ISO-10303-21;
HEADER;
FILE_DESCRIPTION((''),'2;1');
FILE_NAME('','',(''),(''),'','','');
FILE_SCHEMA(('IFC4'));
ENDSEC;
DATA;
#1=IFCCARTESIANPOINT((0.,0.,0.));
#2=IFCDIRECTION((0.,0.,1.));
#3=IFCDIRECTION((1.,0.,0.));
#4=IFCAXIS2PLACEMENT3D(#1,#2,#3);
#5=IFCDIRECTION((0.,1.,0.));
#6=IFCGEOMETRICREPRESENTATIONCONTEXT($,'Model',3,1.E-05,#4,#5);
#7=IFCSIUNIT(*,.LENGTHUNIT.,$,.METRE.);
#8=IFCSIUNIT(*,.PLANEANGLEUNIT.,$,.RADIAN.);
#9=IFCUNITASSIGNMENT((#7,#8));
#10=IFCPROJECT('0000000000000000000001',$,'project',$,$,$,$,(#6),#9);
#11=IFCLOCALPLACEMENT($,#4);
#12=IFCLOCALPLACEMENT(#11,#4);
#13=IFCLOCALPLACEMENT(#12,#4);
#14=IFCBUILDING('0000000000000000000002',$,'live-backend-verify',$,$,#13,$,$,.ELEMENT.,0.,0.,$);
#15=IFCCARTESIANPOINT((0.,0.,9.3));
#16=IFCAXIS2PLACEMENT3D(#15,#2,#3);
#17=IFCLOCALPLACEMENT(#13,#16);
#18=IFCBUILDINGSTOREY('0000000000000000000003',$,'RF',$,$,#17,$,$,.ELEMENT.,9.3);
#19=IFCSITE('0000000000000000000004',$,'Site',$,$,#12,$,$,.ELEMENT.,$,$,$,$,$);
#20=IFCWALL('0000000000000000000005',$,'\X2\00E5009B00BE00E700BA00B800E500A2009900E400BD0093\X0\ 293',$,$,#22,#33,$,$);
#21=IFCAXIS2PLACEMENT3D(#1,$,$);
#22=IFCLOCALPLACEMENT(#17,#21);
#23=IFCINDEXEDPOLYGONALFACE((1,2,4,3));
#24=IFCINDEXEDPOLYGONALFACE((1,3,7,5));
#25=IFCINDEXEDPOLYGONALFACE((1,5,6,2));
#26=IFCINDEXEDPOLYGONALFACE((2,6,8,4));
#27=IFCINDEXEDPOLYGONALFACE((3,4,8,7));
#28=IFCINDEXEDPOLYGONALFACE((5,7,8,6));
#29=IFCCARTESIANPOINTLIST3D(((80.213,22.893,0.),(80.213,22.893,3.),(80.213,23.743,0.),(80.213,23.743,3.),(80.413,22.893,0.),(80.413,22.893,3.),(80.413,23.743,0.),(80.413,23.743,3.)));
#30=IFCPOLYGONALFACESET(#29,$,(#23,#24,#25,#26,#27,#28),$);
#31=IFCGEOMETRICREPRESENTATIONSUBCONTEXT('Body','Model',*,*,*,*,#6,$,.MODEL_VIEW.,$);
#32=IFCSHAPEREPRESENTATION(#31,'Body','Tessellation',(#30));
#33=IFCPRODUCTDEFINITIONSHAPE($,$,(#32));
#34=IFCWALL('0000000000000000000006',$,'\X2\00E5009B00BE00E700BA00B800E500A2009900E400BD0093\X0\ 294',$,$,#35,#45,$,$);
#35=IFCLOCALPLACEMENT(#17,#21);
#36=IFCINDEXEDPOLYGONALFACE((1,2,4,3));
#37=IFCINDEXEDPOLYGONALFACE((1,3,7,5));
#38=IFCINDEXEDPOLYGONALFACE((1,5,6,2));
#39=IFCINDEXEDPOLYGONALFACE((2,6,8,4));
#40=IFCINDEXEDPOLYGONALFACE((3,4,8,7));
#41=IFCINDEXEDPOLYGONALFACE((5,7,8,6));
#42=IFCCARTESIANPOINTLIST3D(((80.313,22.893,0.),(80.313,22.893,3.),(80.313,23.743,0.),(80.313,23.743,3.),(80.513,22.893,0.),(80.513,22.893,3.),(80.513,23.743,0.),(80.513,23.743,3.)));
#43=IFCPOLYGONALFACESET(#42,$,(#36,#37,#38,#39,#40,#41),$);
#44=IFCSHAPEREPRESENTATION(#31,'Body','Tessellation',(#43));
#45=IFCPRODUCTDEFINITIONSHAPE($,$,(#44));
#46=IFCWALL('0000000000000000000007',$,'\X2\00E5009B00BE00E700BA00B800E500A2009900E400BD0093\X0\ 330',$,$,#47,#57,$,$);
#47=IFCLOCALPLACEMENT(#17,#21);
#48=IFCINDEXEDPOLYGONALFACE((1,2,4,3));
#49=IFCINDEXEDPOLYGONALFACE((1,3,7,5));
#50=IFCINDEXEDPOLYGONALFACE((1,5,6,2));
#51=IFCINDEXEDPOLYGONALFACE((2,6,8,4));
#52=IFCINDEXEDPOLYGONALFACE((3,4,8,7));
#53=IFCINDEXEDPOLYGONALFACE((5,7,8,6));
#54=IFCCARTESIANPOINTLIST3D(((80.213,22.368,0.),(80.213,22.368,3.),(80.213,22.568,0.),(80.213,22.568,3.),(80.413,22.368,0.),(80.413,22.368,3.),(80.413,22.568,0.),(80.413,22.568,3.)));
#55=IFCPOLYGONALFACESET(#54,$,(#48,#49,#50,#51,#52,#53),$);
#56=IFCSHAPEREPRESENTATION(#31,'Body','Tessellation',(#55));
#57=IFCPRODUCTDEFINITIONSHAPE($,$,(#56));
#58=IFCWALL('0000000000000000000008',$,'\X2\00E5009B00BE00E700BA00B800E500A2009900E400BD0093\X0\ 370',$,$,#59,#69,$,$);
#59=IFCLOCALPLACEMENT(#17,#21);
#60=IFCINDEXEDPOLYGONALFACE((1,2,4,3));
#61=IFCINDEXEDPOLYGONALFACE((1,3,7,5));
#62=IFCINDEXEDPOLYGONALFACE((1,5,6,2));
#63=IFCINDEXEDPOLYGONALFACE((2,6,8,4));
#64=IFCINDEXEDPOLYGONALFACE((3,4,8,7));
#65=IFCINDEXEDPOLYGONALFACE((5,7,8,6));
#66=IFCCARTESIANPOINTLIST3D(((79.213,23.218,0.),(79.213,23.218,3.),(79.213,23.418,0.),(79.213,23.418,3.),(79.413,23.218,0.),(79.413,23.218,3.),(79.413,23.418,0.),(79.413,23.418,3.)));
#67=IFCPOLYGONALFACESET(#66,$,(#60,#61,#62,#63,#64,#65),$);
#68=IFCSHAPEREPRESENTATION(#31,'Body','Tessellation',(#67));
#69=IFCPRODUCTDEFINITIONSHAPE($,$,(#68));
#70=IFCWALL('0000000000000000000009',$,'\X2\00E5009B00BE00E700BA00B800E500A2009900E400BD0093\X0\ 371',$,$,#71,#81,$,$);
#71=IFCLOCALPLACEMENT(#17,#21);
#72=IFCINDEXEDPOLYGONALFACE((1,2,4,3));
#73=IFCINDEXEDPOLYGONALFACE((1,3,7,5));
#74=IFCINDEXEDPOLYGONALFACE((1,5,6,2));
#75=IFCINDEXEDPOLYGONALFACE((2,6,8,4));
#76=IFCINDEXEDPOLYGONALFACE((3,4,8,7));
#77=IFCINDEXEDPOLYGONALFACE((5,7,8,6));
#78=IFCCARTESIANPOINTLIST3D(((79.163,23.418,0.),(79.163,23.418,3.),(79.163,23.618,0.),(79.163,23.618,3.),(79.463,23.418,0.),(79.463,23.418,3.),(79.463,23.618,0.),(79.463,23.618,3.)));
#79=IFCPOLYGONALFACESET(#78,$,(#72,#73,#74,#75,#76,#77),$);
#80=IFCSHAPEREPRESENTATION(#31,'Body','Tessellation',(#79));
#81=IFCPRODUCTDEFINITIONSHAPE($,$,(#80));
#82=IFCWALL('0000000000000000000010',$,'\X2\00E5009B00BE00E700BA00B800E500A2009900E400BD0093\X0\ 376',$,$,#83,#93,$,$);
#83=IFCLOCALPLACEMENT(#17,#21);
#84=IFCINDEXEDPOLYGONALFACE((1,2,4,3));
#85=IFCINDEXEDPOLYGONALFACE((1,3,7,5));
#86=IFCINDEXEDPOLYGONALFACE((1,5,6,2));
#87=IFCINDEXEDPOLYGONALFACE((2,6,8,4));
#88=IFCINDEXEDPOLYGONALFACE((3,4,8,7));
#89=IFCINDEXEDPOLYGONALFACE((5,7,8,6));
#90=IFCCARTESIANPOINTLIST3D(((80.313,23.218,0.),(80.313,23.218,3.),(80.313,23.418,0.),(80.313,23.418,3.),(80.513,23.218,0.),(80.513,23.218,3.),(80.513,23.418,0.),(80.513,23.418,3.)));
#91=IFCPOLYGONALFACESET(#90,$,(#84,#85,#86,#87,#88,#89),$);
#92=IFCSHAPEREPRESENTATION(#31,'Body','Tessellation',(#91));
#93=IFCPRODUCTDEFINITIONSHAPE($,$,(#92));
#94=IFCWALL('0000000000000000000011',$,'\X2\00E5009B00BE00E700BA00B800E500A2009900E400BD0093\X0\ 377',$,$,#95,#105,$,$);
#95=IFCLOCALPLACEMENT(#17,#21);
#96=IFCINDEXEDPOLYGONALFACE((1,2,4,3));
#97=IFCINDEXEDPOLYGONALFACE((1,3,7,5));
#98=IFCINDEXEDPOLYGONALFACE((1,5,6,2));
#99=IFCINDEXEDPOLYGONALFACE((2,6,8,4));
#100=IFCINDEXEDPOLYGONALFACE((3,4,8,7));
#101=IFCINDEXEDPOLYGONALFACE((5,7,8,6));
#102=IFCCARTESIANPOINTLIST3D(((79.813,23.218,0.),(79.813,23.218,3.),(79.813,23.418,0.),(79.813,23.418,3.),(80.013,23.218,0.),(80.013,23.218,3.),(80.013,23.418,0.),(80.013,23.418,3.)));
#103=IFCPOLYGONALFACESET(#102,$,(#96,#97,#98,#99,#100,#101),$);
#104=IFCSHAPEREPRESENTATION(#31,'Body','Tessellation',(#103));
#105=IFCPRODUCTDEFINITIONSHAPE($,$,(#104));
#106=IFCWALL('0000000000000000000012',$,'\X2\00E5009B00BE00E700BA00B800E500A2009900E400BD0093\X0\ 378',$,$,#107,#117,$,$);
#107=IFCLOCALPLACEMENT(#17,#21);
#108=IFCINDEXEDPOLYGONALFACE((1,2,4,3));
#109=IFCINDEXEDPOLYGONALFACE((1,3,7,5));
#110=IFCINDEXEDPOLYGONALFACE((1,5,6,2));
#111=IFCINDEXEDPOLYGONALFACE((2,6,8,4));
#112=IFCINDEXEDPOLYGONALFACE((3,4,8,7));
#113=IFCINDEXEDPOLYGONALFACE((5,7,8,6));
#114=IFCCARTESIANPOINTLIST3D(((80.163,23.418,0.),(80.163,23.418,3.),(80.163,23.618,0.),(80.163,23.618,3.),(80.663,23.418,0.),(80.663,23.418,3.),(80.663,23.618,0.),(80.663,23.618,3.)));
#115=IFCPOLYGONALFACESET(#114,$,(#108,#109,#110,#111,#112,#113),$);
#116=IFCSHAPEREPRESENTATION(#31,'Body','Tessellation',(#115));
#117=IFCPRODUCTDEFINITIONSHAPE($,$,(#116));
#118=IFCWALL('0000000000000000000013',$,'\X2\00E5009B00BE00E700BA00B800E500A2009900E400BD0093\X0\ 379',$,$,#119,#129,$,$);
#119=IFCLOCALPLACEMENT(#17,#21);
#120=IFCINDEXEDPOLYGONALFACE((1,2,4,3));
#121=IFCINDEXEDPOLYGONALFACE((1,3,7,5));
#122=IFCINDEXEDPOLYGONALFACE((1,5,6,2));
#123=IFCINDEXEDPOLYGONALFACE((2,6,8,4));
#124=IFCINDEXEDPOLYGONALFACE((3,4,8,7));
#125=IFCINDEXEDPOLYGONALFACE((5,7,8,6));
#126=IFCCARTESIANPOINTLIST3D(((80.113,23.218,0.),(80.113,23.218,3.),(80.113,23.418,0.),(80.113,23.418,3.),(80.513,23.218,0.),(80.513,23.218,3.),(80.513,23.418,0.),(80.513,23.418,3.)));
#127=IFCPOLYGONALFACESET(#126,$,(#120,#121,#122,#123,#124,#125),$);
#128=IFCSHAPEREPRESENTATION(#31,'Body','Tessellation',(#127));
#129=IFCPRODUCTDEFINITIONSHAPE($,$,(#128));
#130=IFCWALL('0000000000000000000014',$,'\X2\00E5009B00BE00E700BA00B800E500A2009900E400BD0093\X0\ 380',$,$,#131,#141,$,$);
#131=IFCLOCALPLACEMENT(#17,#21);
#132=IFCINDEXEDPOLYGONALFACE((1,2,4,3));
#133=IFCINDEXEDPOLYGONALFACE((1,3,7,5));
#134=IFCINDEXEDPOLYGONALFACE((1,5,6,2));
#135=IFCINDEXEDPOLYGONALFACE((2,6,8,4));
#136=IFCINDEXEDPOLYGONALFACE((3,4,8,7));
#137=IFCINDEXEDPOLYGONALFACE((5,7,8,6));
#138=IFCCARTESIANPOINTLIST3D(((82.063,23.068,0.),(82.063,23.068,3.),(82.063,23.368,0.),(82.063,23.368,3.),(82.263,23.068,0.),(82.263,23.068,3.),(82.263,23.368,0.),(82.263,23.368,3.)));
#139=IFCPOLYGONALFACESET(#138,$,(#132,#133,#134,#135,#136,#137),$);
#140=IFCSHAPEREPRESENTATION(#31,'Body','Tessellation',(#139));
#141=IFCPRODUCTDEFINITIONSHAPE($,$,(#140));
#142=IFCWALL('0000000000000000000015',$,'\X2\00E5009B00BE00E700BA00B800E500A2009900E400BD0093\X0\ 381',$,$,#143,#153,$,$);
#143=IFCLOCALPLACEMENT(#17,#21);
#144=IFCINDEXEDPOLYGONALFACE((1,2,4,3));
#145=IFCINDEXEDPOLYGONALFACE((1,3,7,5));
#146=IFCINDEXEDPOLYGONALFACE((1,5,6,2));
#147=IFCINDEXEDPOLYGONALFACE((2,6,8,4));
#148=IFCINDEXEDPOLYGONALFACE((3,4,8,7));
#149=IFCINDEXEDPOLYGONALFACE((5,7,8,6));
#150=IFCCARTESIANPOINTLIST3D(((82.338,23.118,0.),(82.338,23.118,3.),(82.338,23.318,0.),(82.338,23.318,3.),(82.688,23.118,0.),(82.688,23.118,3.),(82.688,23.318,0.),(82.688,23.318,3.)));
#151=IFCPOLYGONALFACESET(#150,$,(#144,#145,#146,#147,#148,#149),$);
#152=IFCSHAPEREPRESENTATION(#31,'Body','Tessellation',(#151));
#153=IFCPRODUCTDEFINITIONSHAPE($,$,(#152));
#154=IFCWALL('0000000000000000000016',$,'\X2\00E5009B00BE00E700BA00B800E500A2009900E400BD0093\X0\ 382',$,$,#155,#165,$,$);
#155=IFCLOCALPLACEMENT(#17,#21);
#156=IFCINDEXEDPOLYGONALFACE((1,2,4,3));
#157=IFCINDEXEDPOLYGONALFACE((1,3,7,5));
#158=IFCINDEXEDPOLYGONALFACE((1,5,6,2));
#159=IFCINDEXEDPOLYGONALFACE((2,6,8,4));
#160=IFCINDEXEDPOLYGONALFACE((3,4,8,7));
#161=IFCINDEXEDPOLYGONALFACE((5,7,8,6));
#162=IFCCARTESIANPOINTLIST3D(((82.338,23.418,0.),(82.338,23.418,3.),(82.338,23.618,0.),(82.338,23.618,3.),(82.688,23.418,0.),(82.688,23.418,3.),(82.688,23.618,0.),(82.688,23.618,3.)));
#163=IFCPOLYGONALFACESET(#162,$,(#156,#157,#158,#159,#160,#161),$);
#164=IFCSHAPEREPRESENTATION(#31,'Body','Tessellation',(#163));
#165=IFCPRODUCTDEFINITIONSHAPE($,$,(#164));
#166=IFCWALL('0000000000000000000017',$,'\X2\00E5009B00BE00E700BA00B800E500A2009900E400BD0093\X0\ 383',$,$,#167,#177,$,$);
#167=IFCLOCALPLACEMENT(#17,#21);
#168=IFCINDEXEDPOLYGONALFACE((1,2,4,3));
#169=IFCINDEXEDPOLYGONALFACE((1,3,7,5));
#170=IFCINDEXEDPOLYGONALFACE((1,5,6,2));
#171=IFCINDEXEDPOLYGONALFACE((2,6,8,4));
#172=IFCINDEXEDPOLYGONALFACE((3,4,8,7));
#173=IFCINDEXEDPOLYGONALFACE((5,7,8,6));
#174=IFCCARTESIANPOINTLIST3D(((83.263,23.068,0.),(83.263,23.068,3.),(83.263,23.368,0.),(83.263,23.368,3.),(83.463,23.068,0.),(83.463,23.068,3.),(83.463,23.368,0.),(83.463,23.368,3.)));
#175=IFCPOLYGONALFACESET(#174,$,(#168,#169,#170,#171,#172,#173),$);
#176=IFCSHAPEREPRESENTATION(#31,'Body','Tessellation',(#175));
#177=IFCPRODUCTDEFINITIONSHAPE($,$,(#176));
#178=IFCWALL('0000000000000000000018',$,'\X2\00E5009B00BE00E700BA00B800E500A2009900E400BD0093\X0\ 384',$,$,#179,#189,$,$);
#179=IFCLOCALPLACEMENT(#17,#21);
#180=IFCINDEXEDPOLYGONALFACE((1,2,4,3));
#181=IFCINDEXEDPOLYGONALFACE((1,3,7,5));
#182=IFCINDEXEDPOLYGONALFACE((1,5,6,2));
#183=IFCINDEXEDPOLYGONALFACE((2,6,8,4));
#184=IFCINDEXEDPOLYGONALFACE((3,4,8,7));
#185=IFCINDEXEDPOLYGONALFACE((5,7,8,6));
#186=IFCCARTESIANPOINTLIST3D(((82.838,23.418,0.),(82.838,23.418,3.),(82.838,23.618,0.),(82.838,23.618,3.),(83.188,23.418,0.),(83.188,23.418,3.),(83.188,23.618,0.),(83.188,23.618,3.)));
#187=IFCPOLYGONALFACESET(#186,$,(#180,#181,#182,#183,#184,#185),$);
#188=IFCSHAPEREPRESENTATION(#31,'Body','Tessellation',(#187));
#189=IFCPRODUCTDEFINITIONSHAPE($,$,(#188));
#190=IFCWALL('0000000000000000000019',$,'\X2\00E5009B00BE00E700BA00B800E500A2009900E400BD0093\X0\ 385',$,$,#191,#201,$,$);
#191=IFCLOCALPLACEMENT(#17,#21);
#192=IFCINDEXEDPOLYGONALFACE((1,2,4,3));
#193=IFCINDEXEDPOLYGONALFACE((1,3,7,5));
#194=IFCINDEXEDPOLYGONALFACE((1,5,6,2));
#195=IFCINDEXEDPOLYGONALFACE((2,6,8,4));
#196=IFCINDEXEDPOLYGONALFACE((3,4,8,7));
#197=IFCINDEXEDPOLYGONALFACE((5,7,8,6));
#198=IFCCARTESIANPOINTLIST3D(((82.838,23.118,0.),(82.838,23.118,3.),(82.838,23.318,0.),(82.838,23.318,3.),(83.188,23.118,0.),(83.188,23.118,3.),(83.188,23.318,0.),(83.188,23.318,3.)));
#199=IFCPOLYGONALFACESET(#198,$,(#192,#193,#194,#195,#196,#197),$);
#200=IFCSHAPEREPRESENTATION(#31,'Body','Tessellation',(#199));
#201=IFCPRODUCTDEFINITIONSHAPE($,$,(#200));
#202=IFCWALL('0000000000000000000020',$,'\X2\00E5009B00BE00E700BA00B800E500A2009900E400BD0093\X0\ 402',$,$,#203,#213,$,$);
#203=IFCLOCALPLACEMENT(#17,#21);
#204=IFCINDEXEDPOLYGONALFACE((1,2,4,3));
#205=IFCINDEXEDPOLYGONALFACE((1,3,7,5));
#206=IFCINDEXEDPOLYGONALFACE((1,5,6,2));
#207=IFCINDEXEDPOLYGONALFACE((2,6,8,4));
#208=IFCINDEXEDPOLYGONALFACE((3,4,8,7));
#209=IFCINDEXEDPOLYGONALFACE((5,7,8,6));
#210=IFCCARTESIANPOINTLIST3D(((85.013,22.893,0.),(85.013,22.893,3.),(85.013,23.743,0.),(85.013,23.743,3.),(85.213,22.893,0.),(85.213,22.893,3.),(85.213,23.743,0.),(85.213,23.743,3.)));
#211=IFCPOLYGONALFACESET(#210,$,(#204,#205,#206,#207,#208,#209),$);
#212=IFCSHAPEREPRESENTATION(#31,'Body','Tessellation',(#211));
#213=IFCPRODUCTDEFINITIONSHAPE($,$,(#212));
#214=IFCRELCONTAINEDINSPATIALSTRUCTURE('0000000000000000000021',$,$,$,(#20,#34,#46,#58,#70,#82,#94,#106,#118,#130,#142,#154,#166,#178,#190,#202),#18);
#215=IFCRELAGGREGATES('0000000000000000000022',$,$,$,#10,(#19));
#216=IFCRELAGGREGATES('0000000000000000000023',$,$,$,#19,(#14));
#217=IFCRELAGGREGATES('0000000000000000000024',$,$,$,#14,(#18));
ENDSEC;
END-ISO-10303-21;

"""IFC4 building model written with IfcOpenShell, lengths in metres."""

from ifc_helpers import new_model, si_unit, direction, frame, frame_2d, origin_with_axes, place, context, subcontext, project, spatial, rectangle, extrude, element, save


model = new_model("IFC4")

# Units and contexts
model_context = context("Model", 3, precision=1e-05, world=origin_with_axes(), true_north=direction((0.0, 1.0, 0.0)))
body_context = subcontext(model_context, "Body", "Model", "MODEL_VIEW")
ifc_project = project(units=[si_unit("LENGTHUNIT", "METRE"), si_unit("PLANEANGLEUNIT", "RADIAN")], contexts=[model_context])

# Site, building, storey
placement = place(None, origin_with_axes())
site_placement = place(placement, origin_with_axes())
site = spatial("IfcSite", under=ifc_project, at=site_placement, Name="Site", CompositionType="ELEMENT")
building_placement = place(site_placement, origin_with_axes())
building = spatial("IfcBuilding", under=site, at=building_placement, Name="live-backend-verify", CompositionType="ELEMENT", ElevationOfRefHeight=0.0, ElevationOfTerrain=0.0)
storey_placement = place(building_placement, frame((0.0, 0.0, 9.3), z_axis=(0.0, 0.0, 1.0), x_axis=(1.0, 0.0, 0.0)))
storey = spatial("IfcBuildingStorey", under=building, at=storey_placement, Name="RF", CompositionType="ELEMENT", Elevation=9.3)

# Walls
for number, where, z_axis, x_axis, name in (
    (1, (80.313, 23.318, 0.0), (0.0, 0.0, 1.0), (0.0, -1.0, 0.0), "å\u009b¾çº¸å¢\u0099ä½\u0093 293"),
    (2, (80.413, 23.318, 0.0), (0.0, 0.0, 1.0), (0.0, -1.0, 0.0), "å\u009b¾çº¸å¢\u0099ä½\u0093 294"),
):
    element("IfcWall", number, at=place(storey_placement, frame(where, z_axis=z_axis, x_axis=x_axis)), inside=storey, Name=name, context=body_context, shape_type="SweptSolid", body=[
        extrude(rectangle(XDim=0.85, YDim=0.2, at=frame_2d((0.0, 0.0), x_axis=(1.0, 0.0, 0.0))), frame((0.0, 0.0, 0.0), z_axis=(0.0, 0.0, 1.0)), (0.0, 0.0, 1.0), 3.0),
    ])
for number, where, z_axis, x_axis, name in (
    (3, (80.313, 22.468, 0.0), (0.0, 0.0, 1.0), (1.0, 0.0, 0.0), "å\u009b¾çº¸å¢\u0099ä½\u0093 330"),
    (4, (79.313, 23.318, 0.0), (0.0, 0.0, 1.0), (-1.0, 0.0, 0.0), "å\u009b¾çº¸å¢\u0099ä½\u0093 370"),
):
    element("IfcWall", number, at=place(storey_placement, frame(where, z_axis=z_axis, x_axis=x_axis)), inside=storey, Name=name, context=body_context, shape_type="SweptSolid", body=[
        extrude(rectangle(XDim=0.2, YDim=0.2, at=frame_2d((0.0, 0.0), x_axis=(1.0, 0.0, 0.0))), frame((0.0, 0.0, 0.0), z_axis=(0.0, 0.0, 1.0)), (0.0, 0.0, 1.0), 3.0),
    ])
wall_1_placement = place(storey_placement, frame((79.313, 23.518, 0.0), z_axis=(0.0, 0.0, 1.0), x_axis=(-1.0, 0.0, 0.0)))
element("IfcWall", 5, at=wall_1_placement, inside=storey, Name="å\u009b¾çº¸å¢\u0099ä½\u0093 371", context=body_context, shape_type="SweptSolid", body=[
    extrude(rectangle(XDim=0.3, YDim=0.2, at=frame_2d((0.0, 0.0), x_axis=(1.0, 0.0, 0.0))), frame((0.0, 0.0, 0.0), z_axis=(0.0, 0.0, 1.0)), (0.0, 0.0, 1.0), 3.0),
])
for number, where, z_axis, x_axis, name in (
    (6, (80.413, 23.318, 0.0), (0.0, 0.0, 1.0), (0.0, 1.0, 0.0), "å\u009b¾çº¸å¢\u0099ä½\u0093 376"),
    (7, (79.913, 23.318, 0.0), (0.0, 0.0, 1.0), (0.0, 1.0, 0.0), "å\u009b¾çº¸å¢\u0099ä½\u0093 377"),
):
    element("IfcWall", number, at=place(storey_placement, frame(where, z_axis=z_axis, x_axis=x_axis)), inside=storey, Name=name, context=body_context, shape_type="SweptSolid", body=[
        extrude(rectangle(XDim=0.2, YDim=0.2, at=frame_2d((0.0, 0.0), x_axis=(1.0, 0.0, 0.0))), frame((0.0, 0.0, 0.0), z_axis=(0.0, 0.0, 1.0)), (0.0, 0.0, 1.0), 3.0),
    ])
wall_2_placement = place(storey_placement, frame((80.413, 23.518, 0.0), z_axis=(0.0, 0.0, 1.0), x_axis=(-1.0, 0.0, 0.0)))
element("IfcWall", 8, at=wall_2_placement, inside=storey, Name="å\u009b¾çº¸å¢\u0099ä½\u0093 378", context=body_context, shape_type="SweptSolid", body=[
    extrude(rectangle(XDim=0.5, YDim=0.2, at=frame_2d((0.0, 0.0), x_axis=(1.0, 0.0, 0.0))), frame((0.0, 0.0, 0.0), z_axis=(0.0, 0.0, 1.0)), (0.0, 0.0, 1.0), 3.0),
])
wall_3_placement = place(storey_placement, frame((80.313, 23.318, 0.0), z_axis=(0.0, 0.0, 1.0), x_axis=(-1.0, 0.0, 0.0)))
element("IfcWall", 9, at=wall_3_placement, inside=storey, Name="å\u009b¾çº¸å¢\u0099ä½\u0093 379", context=body_context, shape_type="SweptSolid", body=[
    extrude(rectangle(XDim=0.4, YDim=0.2, at=frame_2d((0.0, 0.0), x_axis=(1.0, 0.0, 0.0))), frame((0.0, 0.0, 0.0), z_axis=(0.0, 0.0, 1.0)), (0.0, 0.0, 1.0), 3.0),
])
wall_4_placement = place(storey_placement, frame((82.163, 23.218, 0.0), z_axis=(0.0, 0.0, 1.0), x_axis=(0.0, 1.0, 0.0)))
element("IfcWall", 10, at=wall_4_placement, inside=storey, Name="å\u009b¾çº¸å¢\u0099ä½\u0093 380", context=body_context, shape_type="SweptSolid", body=[
    extrude(rectangle(XDim=0.3, YDim=0.2, at=frame_2d((0.0, 0.0), x_axis=(1.0, 0.0, 0.0))), frame((0.0, 0.0, 0.0), z_axis=(0.0, 0.0, 1.0)), (0.0, 0.0, 1.0), 3.0),
])
for number, where, z_axis, x_axis, name in (
    (11, (82.513, 23.218, 0.0), (0.0, 0.0, 1.0), (-1.0, 0.0, 0.0), "å\u009b¾çº¸å¢\u0099ä½\u0093 381"),
    (12, (82.513, 23.518, 0.0), (0.0, 0.0, 1.0), (-1.0, 0.0, 0.0), "å\u009b¾çº¸å¢\u0099ä½\u0093 382"),
):
    element("IfcWall", number, at=place(storey_placement, frame(where, z_axis=z_axis, x_axis=x_axis)), inside=storey, Name=name, context=body_context, shape_type="SweptSolid", body=[
        extrude(rectangle(XDim=0.35, YDim=0.2, at=frame_2d((0.0, 0.0), x_axis=(1.0, 0.0, 0.0))), frame((0.0, 0.0, 0.0), z_axis=(0.0, 0.0, 1.0)), (0.0, 0.0, 1.0), 3.0),
    ])
wall_5_placement = place(storey_placement, frame((83.363, 23.218, 0.0), z_axis=(0.0, 0.0, 1.0), x_axis=(0.0, 1.0, 0.0)))
element("IfcWall", 13, at=wall_5_placement, inside=storey, Name="å\u009b¾çº¸å¢\u0099ä½\u0093 383", context=body_context, shape_type="SweptSolid", body=[
    extrude(rectangle(XDim=0.3, YDim=0.2, at=frame_2d((0.0, 0.0), x_axis=(1.0, 0.0, 0.0))), frame((0.0, 0.0, 0.0), z_axis=(0.0, 0.0, 1.0)), (0.0, 0.0, 1.0), 3.0),
])
for number, where, z_axis, x_axis, name in (
    (14, (83.013, 23.518, 0.0), (0.0, 0.0, 1.0), (1.0, 0.0, 0.0), "å\u009b¾çº¸å¢\u0099ä½\u0093 384"),
    (15, (83.013, 23.218, 0.0), (0.0, 0.0, 1.0), (1.0, 0.0, 0.0), "å\u009b¾çº¸å¢\u0099ä½\u0093 385"),
):
    element("IfcWall", number, at=place(storey_placement, frame(where, z_axis=z_axis, x_axis=x_axis)), inside=storey, Name=name, context=body_context, shape_type="SweptSolid", body=[
        extrude(rectangle(XDim=0.35, YDim=0.2, at=frame_2d((0.0, 0.0), x_axis=(1.0, 0.0, 0.0))), frame((0.0, 0.0, 0.0), z_axis=(0.0, 0.0, 1.0)), (0.0, 0.0, 1.0), 3.0),
    ])
for number, where, z_axis, x_axis, name in (
    (16, (85.113, 23.318, 0.0), (0.0, 0.0, 1.0), (0.0, -1.0, 0.0), "å\u009b¾çº¸å¢\u0099ä½\u0093 402"),
):
    element("IfcWall", number, at=place(storey_placement, frame(where, z_axis=z_axis, x_axis=x_axis)), inside=storey, Name=name, context=body_context, shape_type="SweptSolid", body=[
        extrude(rectangle(XDim=0.85, YDim=0.2, at=frame_2d((0.0, 0.0), x_axis=(1.0, 0.0, 0.0))), frame((0.0, 0.0, 0.0), z_axis=(0.0, 0.0, 1.0)), (0.0, 0.0, 1.0), 3.0),
    ])

save(model, "model.ifc")
